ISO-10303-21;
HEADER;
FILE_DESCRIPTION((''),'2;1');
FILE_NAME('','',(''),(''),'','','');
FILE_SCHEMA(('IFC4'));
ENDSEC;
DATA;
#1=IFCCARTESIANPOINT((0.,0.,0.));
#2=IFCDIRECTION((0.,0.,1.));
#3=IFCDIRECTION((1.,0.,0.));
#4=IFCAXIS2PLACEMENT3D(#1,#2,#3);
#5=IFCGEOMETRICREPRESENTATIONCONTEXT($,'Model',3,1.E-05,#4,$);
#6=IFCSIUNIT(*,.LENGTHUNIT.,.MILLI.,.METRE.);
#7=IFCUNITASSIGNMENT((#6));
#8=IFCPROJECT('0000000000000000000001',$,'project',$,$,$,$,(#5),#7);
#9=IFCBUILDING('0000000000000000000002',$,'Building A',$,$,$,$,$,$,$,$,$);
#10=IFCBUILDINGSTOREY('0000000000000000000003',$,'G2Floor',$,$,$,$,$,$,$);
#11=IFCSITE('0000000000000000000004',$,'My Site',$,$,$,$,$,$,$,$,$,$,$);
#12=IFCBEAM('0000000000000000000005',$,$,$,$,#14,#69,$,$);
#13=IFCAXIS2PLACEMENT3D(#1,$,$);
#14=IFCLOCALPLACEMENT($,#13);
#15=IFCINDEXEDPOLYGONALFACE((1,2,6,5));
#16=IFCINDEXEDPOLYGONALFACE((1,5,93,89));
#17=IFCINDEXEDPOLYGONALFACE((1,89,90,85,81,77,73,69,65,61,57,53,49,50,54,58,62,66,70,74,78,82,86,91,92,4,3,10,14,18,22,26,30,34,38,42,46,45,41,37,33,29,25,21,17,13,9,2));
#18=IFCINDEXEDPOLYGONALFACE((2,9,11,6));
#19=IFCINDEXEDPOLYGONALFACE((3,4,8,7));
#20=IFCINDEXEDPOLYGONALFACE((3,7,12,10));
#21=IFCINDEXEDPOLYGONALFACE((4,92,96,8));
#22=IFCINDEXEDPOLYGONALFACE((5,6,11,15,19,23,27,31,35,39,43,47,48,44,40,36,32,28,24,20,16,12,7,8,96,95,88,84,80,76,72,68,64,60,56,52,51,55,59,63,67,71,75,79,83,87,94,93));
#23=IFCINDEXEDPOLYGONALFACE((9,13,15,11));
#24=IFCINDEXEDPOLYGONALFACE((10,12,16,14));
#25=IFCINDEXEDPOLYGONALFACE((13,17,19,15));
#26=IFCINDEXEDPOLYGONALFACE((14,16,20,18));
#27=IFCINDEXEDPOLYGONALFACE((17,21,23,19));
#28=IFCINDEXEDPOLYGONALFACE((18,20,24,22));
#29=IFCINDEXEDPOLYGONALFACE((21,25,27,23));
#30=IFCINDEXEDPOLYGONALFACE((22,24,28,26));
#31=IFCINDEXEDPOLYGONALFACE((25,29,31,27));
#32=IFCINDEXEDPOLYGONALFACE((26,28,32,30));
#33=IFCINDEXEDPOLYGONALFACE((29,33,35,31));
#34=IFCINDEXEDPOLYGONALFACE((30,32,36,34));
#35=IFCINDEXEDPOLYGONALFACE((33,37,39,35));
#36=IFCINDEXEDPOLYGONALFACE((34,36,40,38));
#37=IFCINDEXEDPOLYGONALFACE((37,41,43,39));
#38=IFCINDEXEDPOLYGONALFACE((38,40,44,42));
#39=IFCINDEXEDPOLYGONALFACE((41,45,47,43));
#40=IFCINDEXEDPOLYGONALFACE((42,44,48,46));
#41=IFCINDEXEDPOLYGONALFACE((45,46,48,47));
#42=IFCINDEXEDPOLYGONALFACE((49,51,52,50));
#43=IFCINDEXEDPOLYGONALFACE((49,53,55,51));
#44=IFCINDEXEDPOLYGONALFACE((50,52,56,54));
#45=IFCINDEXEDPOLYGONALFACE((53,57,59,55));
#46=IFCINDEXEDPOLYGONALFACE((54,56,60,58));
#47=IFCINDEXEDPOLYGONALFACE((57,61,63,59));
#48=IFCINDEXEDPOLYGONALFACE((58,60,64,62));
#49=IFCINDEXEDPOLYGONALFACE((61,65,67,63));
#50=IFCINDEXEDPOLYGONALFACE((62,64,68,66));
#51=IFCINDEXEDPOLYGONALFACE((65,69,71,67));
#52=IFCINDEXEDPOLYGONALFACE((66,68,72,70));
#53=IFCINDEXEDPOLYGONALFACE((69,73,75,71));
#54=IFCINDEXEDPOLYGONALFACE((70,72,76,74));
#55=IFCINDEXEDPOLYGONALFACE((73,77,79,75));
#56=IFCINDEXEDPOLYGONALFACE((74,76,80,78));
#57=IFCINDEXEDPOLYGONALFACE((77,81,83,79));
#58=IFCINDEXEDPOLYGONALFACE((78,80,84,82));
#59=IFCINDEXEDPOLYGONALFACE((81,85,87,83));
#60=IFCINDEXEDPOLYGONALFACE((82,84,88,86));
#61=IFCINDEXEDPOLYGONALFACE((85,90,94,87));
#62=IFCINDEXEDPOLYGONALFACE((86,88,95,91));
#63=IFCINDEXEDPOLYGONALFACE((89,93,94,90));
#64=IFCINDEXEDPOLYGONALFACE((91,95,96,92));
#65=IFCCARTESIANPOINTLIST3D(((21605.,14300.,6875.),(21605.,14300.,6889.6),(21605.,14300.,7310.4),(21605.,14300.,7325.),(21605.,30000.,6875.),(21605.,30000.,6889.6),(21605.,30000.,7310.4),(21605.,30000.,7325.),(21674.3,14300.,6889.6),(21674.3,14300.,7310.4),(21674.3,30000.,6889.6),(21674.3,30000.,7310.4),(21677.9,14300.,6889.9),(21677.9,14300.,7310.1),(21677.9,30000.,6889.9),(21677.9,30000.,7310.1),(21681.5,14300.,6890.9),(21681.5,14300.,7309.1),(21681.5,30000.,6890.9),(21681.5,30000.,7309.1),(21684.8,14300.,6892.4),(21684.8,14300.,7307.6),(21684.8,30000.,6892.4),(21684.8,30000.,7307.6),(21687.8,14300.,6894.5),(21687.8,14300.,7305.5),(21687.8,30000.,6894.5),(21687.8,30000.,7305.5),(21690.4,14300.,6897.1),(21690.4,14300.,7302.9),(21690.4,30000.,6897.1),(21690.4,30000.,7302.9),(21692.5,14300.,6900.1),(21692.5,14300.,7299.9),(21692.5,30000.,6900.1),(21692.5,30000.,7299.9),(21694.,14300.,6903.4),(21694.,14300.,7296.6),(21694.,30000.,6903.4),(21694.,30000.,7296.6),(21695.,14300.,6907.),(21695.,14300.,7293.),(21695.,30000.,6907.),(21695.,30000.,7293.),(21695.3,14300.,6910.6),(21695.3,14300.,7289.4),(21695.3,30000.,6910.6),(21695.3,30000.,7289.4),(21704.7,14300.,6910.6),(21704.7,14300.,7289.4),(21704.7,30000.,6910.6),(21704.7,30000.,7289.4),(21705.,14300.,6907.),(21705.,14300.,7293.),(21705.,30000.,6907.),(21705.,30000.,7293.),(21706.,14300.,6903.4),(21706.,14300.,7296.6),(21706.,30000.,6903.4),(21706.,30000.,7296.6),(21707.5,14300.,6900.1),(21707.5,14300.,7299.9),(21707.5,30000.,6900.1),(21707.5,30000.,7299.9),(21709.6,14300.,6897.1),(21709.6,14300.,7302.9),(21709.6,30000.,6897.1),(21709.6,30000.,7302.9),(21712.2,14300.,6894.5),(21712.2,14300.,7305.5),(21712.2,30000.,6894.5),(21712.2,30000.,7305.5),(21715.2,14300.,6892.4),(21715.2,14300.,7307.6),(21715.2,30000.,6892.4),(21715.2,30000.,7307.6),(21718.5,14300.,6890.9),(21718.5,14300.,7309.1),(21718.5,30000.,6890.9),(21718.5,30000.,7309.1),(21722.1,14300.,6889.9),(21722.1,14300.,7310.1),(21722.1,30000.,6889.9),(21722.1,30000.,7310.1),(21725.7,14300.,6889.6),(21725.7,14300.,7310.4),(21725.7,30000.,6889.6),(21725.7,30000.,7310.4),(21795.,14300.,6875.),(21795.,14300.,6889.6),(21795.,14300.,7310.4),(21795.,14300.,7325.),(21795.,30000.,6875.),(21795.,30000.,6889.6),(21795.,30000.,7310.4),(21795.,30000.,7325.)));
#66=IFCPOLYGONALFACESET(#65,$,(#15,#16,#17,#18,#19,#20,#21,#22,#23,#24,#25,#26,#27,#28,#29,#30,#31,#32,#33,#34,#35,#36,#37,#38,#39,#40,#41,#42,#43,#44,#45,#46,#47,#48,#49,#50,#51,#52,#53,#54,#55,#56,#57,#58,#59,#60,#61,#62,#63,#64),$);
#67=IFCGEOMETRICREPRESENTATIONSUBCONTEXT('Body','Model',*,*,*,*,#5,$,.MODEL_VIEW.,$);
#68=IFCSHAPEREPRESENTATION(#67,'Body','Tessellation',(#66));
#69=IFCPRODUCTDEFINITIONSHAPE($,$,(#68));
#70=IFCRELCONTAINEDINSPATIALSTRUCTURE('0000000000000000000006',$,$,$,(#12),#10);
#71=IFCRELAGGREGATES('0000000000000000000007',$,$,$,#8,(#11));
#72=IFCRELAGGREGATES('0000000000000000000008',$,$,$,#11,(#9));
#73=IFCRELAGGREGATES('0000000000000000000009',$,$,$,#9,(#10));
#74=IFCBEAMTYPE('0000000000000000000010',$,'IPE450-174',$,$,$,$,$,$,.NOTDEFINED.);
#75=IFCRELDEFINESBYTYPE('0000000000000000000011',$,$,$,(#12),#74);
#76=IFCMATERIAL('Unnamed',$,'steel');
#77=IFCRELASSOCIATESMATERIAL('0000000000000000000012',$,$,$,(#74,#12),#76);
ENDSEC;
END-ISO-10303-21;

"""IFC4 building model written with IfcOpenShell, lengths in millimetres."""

from ifc_helpers import new_model, si_unit, frame, origin_with_axes, place, context, subcontext, project, spatial, polyline, outline, extrude, material, material_profile, profile_set, profile_usage, type_object, element, save


model = new_model("IFC4")

# Units and contexts
model_context = context("Model", 3, precision=1e-05, world=origin_with_axes())
body_context = subcontext(model_context, "Body", "Model", "MODEL_VIEW")
ifc_project = project(units=[si_unit("LENGTHUNIT", "METRE", prefix="MILLI")], contexts=[model_context])

# Site, building, storey
site = spatial("IfcSite", under=ifc_project, Name="My Site")
building = spatial("IfcBuilding", under=site, Name="Building A")
storey = spatial("IfcBuildingStorey", under=building, Name="G2Floor")

# Beam
ifc_material_1 = material(Name="Unnamed", Category="steel")
ifc_material_profile_1 = material_profile(ifc_material_1, outline(polyline([(95.0, -225.0), (95.0, -210.4), (95.0, -210.4), (25.7, -210.4), (25.7, -210.4), (22.1, -210.1), (22.1, -210.1), (18.5, -209.1), (18.5, -209.1), (15.2, -207.6), (15.2, -207.6), (12.2, -205.5), (12.2, -205.5), (9.6, -202.9), (9.6, -202.9), (7.5, -199.9), (7.5, -199.9), (6.0, -196.6), (6.0, -196.6), (5.0, -193.0), (5.0, -193.0), (4.7, -189.4), (4.7, -189.4), (4.7, 189.4), (4.7, 189.4), (5.0, 193.0), (5.0, 193.0), (6.0, 196.6), (6.0, 196.6), (7.5, 199.9), (7.5, 199.9), (9.6, 202.9), (9.6, 202.9), (12.2, 205.5), (12.2, 205.5), (15.2, 207.6), (15.2, 207.6), (18.5, 209.1), (18.5, 209.1), (22.1, 210.1), (22.1, 210.1), (25.7, 210.4), (25.7, 210.4), (95.0, 210.4), (95.0, 210.4), (95.0, 225.0), (95.0, 225.0), (-95.0, 225.0), (-95.0, 225.0), (-95.0, 210.4), (-95.0, 210.4), (-25.7, 210.4), (-25.7, 210.4), (-22.1, 210.1), (-22.1, 210.1), (-18.5, 209.1), (-18.5, 209.1), (-15.2, 207.6), (-15.2, 207.6), (-12.2, 205.5), (-12.2, 205.5), (-9.6, 202.9), (-9.6, 202.9), (-7.5, 199.9), (-7.5, 199.9), (-6.0, 196.6), (-6.0, 196.6), (-5.0, 193.0), (-5.0, 193.0), (-4.7, 189.4), (-4.7, 189.4), (-4.7, -189.4), (-4.7, -189.4), (-5.0, -193.0), (-5.0, -193.0), (-6.0, -196.6), (-6.0, -196.6), (-7.5, -199.9), (-7.5, -199.9), (-9.6, -202.9), (-9.6, -202.9), (-12.2, -205.5), (-12.2, -205.5), (-15.2, -207.6), (-15.2, -207.6), (-18.5, -209.1), (-18.5, -209.1), (-22.1, -210.1), (-22.1, -210.1), (-25.7, -210.4), (-25.7, -210.4), (-95.0, -210.4), (-95.0, -210.4), (-95.0, -225.0), (-95.0, -225.0), (95.0, -225.0)])))
ifc_profile_set_1 = profile_set([ifc_material_profile_1], Name="IPE450-174")
ifc_profile_usage_1 = profile_usage(ifc_profile_set_1)
beam_type_1 = type_object("IfcBeamType", Name="IPE450-174", PredefinedType="NOTDEFINED", material=ifc_profile_set_1)
beam_1_placement = place(None, frame((21700.0, 14300.0, 7100.0), z_axis=(0.0, 1.0, 0.0), x_axis=(1.0, 0.0, 0.0)))
element("IfcBeam", 1, at=beam_1_placement, inside=storey, type_object=beam_type_1, material=ifc_profile_usage_1, context=body_context, shape_type="SweptSolid", body=[
    extrude(outline(polyline([(95.0, -225.0), (95.0, -210.4), (95.0, -210.4), (25.7, -210.4), (25.7, -210.4), (22.1, -210.1), (22.1, -210.1), (18.5, -209.1), (18.5, -209.1), (15.2, -207.6), (15.2, -207.6), (12.2, -205.5), (12.2, -205.5), (9.6, -202.9), (9.6, -202.9), (7.5, -199.9), (7.5, -199.9), (6.0, -196.6), (6.0, -196.6), (5.0, -193.0), (5.0, -193.0), (4.7, -189.4), (4.7, -189.4), (4.7, 189.4), (4.7, 189.4), (5.0, 193.0), (5.0, 193.0), (6.0, 196.6), (6.0, 196.6), (7.5, 199.9), (7.5, 199.9), (9.6, 202.9), (9.6, 202.9), (12.2, 205.5), (12.2, 205.5), (15.2, 207.6), (15.2, 207.6), (18.5, 209.1), (18.5, 209.1), (22.1, 210.1), (22.1, 210.1), (25.7, 210.4), (25.7, 210.4), (95.0, 210.4), (95.0, 210.4), (95.0, 225.0), (95.0, 225.0), (-95.0, 225.0), (-95.0, 225.0), (-95.0, 210.4), (-95.0, 210.4), (-25.7, 210.4), (-25.7, 210.4), (-22.1, 210.1), (-22.1, 210.1), (-18.5, 209.1), (-18.5, 209.1), (-15.2, 207.6), (-15.2, 207.6), (-12.2, 205.5), (-12.2, 205.5), (-9.6, 202.9), (-9.6, 202.9), (-7.5, 199.9), (-7.5, 199.9), (-6.0, 196.6), (-6.0, 196.6), (-5.0, 193.0), (-5.0, 193.0), (-4.7, 189.4), (-4.7, 189.4), (-4.7, -189.4), (-4.7, -189.4), (-5.0, -193.0), (-5.0, -193.0), (-6.0, -196.6), (-6.0, -196.6), (-7.5, -199.9), (-7.5, -199.9), (-9.6, -202.9), (-9.6, -202.9), (-12.2, -205.5), (-12.2, -205.5), (-15.2, -207.6), (-15.2, -207.6), (-18.5, -209.1), (-18.5, -209.1), (-22.1, -210.1), (-22.1, -210.1), (-25.7, -210.4), (-25.7, -210.4), (-95.0, -210.4), (-95.0, -210.4), (-95.0, -225.0), (-95.0, -225.0), (95.0, -225.0)])), origin_with_axes(), (0.0, 0.0, 1.0), 15700.0),
])

save(model, "model.ifc")
